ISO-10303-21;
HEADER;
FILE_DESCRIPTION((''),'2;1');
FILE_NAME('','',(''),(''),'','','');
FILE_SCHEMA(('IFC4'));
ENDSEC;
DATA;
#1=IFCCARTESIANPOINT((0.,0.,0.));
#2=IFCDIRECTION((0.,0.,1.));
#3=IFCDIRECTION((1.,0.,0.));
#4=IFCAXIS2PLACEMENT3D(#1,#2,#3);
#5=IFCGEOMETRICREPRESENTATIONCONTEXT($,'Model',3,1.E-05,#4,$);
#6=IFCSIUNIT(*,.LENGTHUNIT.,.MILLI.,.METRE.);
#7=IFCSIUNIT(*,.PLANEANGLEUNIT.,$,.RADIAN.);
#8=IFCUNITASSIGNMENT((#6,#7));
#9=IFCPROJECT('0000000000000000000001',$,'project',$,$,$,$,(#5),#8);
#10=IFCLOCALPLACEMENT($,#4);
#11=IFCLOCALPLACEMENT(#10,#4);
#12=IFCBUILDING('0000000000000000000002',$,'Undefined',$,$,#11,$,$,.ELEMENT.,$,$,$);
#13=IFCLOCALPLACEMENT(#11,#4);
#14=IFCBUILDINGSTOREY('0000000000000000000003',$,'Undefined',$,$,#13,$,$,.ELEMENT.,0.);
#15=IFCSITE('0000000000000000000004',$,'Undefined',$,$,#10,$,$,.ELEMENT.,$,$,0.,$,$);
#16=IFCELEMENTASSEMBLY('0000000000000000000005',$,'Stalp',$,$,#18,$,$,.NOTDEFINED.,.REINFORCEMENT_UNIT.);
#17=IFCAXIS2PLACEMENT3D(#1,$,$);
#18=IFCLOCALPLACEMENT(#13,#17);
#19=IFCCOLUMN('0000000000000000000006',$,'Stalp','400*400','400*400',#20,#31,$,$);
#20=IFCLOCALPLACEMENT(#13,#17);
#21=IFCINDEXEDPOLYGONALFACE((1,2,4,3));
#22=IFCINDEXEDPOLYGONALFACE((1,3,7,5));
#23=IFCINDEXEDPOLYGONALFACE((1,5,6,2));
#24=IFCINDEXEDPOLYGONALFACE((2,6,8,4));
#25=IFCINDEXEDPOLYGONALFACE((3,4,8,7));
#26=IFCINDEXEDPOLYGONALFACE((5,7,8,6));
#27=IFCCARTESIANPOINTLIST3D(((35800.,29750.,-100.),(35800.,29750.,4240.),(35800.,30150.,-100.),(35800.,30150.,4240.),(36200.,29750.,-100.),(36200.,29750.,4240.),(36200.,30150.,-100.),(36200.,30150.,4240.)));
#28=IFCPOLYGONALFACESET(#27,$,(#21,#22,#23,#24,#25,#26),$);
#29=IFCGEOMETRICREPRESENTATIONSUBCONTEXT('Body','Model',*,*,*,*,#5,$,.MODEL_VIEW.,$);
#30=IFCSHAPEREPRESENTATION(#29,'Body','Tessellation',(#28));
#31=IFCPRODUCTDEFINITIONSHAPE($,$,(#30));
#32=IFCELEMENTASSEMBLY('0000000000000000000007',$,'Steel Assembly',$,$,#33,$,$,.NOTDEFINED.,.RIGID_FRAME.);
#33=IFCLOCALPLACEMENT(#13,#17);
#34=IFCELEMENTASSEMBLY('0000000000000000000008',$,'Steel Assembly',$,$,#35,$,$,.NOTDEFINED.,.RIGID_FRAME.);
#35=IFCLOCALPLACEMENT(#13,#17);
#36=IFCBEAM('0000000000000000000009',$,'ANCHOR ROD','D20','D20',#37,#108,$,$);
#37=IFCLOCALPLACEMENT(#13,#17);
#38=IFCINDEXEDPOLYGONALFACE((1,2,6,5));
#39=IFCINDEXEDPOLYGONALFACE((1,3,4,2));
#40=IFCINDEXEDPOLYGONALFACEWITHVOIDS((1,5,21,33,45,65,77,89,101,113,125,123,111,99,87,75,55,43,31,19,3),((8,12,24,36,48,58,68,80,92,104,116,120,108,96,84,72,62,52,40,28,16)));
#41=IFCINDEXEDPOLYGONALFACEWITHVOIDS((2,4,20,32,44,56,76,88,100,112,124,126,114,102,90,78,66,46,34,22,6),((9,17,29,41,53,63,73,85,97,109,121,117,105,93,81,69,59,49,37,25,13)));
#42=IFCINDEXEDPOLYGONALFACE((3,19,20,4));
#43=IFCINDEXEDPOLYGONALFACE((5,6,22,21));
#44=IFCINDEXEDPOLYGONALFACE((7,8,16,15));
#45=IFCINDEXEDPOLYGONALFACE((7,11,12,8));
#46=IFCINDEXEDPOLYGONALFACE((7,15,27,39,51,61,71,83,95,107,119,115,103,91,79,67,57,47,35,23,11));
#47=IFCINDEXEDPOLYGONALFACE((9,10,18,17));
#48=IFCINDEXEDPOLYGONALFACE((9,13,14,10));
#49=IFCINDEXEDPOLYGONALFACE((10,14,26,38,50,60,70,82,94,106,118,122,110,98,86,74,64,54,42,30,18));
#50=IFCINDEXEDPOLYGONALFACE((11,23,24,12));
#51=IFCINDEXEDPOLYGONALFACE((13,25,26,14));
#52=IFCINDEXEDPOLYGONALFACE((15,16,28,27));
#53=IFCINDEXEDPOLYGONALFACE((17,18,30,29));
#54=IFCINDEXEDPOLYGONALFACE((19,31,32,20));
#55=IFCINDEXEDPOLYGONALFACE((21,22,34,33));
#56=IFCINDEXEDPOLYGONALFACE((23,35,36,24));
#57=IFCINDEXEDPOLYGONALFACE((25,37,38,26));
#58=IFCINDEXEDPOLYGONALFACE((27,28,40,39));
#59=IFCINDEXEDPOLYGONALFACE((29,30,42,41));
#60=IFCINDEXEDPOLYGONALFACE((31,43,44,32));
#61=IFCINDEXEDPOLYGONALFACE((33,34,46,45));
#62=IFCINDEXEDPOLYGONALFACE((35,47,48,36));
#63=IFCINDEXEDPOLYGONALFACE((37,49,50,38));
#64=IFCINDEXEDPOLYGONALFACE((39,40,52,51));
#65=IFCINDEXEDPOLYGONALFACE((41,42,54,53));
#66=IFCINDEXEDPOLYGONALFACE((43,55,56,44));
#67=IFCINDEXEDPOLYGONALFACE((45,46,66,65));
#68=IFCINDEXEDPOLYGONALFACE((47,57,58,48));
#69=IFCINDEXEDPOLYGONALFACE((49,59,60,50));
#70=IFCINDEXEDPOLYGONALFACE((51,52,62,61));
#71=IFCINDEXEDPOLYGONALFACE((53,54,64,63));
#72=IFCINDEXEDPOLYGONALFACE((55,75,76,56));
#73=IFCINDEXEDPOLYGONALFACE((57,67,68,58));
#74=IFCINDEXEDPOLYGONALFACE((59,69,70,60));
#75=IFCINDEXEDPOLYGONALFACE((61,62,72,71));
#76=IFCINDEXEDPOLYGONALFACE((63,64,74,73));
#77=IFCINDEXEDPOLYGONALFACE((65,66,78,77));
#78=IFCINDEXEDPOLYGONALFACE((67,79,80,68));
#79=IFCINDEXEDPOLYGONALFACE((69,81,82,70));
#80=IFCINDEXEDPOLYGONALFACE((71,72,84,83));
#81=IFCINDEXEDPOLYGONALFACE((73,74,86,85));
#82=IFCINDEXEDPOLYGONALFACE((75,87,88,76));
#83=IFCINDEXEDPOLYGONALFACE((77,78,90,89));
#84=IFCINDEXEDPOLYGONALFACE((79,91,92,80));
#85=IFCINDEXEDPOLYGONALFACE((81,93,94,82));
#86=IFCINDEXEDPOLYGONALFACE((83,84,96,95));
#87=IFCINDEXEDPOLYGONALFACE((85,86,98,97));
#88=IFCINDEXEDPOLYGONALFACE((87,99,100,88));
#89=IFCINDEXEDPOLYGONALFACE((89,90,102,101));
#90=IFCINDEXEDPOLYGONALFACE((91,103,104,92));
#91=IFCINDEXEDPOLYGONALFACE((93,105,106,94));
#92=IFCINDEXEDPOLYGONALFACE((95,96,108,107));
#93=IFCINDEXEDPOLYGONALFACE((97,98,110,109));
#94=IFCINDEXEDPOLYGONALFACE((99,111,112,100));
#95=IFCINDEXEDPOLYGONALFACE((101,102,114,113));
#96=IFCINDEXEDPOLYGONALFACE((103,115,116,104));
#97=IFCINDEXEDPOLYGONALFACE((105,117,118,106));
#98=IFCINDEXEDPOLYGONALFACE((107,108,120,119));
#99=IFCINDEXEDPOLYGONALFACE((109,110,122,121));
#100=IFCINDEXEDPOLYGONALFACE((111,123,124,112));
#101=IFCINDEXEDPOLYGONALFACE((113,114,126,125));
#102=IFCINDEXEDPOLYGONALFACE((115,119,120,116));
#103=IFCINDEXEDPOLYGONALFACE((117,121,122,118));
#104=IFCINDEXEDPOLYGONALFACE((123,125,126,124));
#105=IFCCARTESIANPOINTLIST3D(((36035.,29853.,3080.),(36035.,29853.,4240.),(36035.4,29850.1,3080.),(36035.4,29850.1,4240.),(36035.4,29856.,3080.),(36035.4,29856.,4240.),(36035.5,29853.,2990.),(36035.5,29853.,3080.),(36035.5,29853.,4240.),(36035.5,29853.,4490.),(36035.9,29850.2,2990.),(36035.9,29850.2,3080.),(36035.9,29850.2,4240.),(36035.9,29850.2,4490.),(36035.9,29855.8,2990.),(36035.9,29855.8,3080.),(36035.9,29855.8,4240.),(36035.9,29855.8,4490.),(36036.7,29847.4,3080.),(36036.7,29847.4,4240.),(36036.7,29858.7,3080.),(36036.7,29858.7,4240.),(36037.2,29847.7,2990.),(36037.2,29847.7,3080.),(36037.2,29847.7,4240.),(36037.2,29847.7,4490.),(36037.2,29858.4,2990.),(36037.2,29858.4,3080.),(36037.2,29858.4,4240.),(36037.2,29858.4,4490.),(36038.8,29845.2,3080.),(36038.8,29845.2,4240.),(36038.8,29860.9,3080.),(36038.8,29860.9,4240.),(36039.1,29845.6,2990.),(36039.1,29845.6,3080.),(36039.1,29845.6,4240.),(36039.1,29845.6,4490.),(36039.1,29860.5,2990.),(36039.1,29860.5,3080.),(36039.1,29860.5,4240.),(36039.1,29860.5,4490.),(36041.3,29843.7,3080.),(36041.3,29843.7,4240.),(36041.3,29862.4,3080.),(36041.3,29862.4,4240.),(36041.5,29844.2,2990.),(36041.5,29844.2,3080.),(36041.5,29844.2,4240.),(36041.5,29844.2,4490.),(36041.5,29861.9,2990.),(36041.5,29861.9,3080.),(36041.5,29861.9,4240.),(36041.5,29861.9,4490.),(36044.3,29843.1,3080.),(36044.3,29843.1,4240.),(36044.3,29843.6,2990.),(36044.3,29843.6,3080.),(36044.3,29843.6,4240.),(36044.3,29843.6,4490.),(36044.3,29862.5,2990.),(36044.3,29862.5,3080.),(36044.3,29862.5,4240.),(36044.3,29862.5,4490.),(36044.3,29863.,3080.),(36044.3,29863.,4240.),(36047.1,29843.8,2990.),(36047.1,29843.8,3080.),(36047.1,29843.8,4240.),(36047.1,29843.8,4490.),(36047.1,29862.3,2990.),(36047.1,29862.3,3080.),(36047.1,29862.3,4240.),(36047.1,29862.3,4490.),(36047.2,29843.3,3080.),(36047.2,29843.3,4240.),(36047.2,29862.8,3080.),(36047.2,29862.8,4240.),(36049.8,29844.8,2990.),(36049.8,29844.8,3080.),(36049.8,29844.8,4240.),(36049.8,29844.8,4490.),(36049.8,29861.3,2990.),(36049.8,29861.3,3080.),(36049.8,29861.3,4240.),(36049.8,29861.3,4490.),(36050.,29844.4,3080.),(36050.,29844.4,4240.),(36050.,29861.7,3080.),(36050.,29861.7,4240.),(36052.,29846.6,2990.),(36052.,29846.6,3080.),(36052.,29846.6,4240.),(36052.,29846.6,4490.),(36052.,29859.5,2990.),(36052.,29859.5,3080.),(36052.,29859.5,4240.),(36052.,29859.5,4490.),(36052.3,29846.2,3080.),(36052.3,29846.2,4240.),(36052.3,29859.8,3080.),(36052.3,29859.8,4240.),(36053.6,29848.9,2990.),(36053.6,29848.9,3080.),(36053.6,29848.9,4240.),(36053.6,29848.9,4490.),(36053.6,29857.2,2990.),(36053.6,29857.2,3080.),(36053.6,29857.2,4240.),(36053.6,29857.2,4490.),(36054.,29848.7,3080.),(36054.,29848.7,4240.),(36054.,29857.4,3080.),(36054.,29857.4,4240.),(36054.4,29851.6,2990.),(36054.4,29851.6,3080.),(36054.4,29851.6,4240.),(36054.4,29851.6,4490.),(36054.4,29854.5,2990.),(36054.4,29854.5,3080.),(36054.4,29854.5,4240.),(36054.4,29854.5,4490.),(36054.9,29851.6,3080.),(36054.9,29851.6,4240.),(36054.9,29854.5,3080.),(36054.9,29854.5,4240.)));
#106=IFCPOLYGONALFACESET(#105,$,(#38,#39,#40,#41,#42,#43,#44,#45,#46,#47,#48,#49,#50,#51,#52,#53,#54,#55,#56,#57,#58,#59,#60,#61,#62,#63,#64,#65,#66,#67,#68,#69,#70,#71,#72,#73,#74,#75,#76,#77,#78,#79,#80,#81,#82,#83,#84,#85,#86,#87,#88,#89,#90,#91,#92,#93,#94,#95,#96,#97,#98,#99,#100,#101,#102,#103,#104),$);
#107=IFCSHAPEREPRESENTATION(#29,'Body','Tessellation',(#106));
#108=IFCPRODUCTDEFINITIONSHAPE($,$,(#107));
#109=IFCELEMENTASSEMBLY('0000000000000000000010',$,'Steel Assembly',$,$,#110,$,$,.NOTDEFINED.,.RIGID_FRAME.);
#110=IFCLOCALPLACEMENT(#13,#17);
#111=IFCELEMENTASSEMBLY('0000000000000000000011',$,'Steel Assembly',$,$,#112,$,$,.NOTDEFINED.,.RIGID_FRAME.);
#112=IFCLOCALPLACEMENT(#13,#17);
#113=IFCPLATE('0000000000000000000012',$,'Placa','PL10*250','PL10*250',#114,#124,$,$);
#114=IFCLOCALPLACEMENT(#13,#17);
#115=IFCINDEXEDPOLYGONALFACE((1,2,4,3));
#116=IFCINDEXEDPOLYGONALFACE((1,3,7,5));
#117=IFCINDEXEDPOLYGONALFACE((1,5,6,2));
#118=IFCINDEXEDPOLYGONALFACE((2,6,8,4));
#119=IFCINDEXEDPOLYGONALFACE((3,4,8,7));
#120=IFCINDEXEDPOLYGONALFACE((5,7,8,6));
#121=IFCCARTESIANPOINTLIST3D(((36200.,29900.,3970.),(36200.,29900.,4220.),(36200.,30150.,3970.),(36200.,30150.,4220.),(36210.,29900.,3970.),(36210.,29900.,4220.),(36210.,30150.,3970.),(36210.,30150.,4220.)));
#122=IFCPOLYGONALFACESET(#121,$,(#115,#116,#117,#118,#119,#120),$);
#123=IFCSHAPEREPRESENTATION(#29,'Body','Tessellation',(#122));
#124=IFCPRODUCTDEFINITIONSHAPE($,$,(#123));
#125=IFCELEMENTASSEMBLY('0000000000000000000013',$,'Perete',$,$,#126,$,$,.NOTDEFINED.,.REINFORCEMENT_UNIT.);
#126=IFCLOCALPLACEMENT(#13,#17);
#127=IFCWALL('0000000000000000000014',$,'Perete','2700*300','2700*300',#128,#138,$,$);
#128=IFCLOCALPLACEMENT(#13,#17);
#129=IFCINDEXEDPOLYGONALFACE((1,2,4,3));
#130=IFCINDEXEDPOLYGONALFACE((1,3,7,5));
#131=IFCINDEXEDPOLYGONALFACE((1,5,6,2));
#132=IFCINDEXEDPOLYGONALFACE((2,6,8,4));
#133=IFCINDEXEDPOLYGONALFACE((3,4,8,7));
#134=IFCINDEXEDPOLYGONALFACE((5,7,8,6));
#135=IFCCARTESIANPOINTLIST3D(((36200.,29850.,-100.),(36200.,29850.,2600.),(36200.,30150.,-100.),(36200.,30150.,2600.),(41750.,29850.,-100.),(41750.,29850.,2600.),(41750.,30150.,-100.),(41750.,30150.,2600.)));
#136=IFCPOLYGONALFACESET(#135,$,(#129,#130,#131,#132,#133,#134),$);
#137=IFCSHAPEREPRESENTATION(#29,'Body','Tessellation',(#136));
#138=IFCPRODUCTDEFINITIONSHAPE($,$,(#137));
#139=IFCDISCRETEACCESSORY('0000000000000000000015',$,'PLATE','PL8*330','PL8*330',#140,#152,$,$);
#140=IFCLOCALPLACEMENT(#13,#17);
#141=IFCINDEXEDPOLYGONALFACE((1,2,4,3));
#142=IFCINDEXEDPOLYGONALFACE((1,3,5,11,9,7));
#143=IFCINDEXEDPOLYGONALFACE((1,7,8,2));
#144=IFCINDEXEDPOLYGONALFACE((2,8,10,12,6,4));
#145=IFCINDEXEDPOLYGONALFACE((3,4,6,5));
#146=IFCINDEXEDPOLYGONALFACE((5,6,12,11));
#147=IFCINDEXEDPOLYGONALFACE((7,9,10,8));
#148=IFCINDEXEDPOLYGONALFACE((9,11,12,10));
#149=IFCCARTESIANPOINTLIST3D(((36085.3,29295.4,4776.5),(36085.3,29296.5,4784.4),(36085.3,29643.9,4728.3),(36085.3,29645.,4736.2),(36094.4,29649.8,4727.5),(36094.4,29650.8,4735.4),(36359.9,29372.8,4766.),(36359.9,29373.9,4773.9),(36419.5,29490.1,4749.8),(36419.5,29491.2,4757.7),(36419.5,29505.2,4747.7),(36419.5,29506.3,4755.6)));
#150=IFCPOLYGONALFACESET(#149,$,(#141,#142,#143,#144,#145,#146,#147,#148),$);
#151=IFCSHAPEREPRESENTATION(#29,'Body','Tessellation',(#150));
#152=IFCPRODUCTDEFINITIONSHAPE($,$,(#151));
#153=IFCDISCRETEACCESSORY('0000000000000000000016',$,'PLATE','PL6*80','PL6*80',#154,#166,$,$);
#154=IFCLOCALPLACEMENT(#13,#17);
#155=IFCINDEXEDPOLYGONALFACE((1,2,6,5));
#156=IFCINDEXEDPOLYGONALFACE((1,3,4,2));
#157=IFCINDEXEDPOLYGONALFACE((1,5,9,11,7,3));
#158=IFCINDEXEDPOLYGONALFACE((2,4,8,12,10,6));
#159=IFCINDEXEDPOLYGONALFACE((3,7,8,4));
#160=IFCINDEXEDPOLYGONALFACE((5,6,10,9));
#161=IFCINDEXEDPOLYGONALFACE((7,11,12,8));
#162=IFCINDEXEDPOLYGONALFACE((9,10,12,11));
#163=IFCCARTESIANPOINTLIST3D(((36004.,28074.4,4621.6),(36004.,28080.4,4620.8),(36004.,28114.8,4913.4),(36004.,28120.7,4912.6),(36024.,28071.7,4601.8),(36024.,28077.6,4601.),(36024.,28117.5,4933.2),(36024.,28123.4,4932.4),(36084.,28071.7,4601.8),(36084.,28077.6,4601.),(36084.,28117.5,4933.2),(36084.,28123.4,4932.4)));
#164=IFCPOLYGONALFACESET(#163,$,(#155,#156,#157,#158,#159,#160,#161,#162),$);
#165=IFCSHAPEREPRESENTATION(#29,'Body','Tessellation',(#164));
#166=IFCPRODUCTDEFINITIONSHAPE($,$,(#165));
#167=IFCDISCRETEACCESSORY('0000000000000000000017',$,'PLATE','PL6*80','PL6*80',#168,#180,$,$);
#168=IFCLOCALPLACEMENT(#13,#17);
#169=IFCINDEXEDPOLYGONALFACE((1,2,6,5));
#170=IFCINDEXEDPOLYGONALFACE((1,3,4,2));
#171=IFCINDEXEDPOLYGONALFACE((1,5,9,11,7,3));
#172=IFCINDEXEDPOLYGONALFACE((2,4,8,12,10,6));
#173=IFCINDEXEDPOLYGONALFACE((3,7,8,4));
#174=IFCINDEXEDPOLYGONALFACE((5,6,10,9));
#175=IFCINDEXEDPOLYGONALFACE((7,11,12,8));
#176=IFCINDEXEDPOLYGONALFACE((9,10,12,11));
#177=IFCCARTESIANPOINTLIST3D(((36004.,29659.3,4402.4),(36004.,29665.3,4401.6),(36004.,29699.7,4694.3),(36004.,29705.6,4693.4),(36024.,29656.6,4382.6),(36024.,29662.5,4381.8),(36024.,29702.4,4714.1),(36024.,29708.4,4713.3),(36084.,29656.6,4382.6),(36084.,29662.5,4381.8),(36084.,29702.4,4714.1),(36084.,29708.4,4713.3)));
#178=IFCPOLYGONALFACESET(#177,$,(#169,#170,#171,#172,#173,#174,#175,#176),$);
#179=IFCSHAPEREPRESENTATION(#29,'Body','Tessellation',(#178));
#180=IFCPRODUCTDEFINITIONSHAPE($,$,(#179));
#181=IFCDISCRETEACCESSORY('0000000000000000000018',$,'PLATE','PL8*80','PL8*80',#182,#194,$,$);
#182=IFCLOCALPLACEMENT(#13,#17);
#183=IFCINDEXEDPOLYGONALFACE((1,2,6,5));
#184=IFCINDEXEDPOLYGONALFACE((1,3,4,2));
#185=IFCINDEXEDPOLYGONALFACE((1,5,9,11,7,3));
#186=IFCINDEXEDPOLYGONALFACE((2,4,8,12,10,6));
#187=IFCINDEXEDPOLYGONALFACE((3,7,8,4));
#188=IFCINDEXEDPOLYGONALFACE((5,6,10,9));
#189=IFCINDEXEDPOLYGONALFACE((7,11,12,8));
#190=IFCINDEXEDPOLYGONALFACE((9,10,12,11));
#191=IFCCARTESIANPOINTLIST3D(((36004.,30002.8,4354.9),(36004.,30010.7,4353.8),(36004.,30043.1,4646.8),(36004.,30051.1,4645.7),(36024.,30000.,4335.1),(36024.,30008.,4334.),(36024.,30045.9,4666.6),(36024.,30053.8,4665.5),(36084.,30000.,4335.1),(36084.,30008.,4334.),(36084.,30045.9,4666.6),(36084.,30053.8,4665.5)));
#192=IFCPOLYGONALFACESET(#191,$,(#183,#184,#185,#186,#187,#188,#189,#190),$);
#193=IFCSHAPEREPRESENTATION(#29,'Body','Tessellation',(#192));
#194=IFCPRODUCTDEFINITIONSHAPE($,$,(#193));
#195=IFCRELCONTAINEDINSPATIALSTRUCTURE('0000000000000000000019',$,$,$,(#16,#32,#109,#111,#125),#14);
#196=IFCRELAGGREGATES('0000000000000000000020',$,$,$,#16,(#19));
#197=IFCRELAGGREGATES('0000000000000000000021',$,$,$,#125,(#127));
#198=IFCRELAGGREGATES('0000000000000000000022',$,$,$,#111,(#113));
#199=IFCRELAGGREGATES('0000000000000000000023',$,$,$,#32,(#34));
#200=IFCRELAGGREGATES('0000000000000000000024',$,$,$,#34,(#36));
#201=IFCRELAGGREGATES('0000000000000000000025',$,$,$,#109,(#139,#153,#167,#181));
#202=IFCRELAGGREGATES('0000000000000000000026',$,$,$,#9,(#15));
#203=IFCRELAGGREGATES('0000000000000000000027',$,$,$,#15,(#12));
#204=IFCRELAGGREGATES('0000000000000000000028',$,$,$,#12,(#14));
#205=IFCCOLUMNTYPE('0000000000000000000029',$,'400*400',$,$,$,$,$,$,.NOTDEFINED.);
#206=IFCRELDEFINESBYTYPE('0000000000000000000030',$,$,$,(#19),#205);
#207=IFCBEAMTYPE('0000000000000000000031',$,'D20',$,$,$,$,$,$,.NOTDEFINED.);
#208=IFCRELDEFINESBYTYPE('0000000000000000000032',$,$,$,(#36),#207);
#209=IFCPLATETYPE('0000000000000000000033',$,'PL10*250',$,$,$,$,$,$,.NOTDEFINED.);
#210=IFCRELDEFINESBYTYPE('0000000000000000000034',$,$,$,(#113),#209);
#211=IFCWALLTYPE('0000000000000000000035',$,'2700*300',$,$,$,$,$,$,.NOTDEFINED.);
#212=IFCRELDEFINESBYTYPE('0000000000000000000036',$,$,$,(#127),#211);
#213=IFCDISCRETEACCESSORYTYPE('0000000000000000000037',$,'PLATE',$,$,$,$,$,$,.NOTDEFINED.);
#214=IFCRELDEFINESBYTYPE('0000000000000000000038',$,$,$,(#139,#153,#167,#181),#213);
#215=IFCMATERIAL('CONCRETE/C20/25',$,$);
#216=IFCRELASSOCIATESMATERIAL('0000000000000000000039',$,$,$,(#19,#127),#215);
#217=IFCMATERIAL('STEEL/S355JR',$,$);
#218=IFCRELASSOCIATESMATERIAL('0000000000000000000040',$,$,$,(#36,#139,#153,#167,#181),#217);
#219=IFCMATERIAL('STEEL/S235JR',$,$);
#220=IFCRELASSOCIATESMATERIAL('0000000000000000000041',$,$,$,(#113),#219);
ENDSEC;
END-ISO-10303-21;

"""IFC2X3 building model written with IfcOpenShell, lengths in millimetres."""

from ifc_helpers import new_model, si_unit, frame, frame_2d, origin_with_axes, origin_2d_with_axis, place, context, subcontext, project, spatial, polyline, rectangle, circle, outline, extrude, boolean, material, type_object, element, aggregate, save


model = new_model("IFC2X3")

# Units and contexts
model_context = context("Model", 3, precision=1e-05, world=origin_with_axes())
body_context = subcontext(model_context, "Body", "Model", "MODEL_VIEW")
ifc_project = project(units=[si_unit("LENGTHUNIT", "METRE", prefix="MILLI"), si_unit("PLANEANGLEUNIT", "RADIAN")], contexts=[model_context])

# Site, building, storey
site_placement = place(None, origin_with_axes())
site = spatial("IfcSite", under=ifc_project, at=site_placement, Name="Undefined", CompositionType="ELEMENT", RefElevation=0.0)
building_placement = place(site_placement, origin_with_axes())
building = spatial("IfcBuilding", under=site, at=building_placement, Name="Undefined", CompositionType="ELEMENT")
storey_placement = place(building_placement, origin_with_axes())
storey = spatial("IfcBuildingStorey", under=building, at=storey_placement, Name="Undefined", CompositionType="ELEMENT", Elevation=0.0)

# Element assembly, column
assembly_1_placement = place(storey_placement, origin_with_axes())
assembly_1 = element("IfcElementAssembly", 1, at=assembly_1_placement, inside=storey, Name="Stalp", AssemblyPlace="NOTDEFINED", PredefinedType="REINFORCEMENT_UNIT")
ifc_material_1 = material(Name="CONCRETE/C20/25")
column_type = type_object("IfcColumnType", Name="400*400", PredefinedType="NOTDEFINED")
column_placement = place(assembly_1_placement, frame((36000.0, 29950.0, -100.0), z_axis=(0.0, 0.0, 1.0), x_axis=(0.0, 1.0, 0.0)))
column = element("IfcColumn", 2, at=column_placement, type_object=column_type, material=ifc_material_1, Name="Stalp", Description="400*400", ObjectType="400*400", context=body_context, shape_type="SweptSolid", body=[
    extrude(rectangle(XDim=400.0, YDim=400.0, at=origin_2d_with_axis()), frame((0.0, 0.0, 4340.0), z_axis=(0.0, 0.0, -1.0), x_axis=(0.0, 1.0, 0.0)), (0.0, 0.0, 1.0), 4340.0),
])
aggregate(assembly_1, [column])

# Shared definitions
ifc_material_2 = material(Name="STEEL/S355JR")

# Element assemblies, beam
assembly_2_placement = place(storey_placement, origin_with_axes())
assembly_2 = element("IfcElementAssembly", 3, at=assembly_2_placement, inside=storey, Name="Steel Assembly", AssemblyPlace="NOTDEFINED", PredefinedType="RIGID_FRAME")
assembly_3_placement = place(assembly_2_placement, origin_with_axes())
assembly_3 = element("IfcElementAssembly", 4, at=assembly_3_placement, Name="Steel Assembly", AssemblyPlace="NOTDEFINED", PredefinedType="RIGID_FRAME")
beam_type_1 = type_object("IfcBeamType", Name="D20", PredefinedType="NOTDEFINED")
beam_1_placement = place(assembly_3_placement, frame((36045.0, 29853.0, 4240.0), z_axis=(0.0, -1.0, 0.0), x_axis=(0.0, 0.0, -1.0)))
beam_1 = element("IfcBeam", 5, at=beam_1_placement, type_object=beam_type_1, material=ifc_material_2, Name="ANCHOR ROD", Description="D20", ObjectType="D20", context=body_context, shape_type="CSG", body=[
    boolean("UNION", boolean("UNION", extrude(circle(Radius=10.0, at=origin_2d_with_axis()), frame((1160.0, 0.0, 0.0), z_axis=(-1.0, 0.0, 0.0), x_axis=(0.0, -1.0, 0.0)), (0.0, 0.0, 1.0), 1160.0), extrude(circle(Radius=9.5, at=origin_2d_with_axis()), frame((1250.0, 0.0, 0.0), z_axis=(-1.0, 0.0, 0.0), x_axis=(0.0, -1.0, 0.0)), (0.0, 0.0, 1.0), 90.0)), extrude(circle(Radius=9.5, at=origin_2d_with_axis()), frame((0.0, 0.0, 0.0), z_axis=(-1.0, 0.0, 0.0), x_axis=(0.0, -1.0, 0.0)), (0.0, 0.0, 1.0), 250.0)),
])

# Element assembly
assembly_4_placement = place(storey_placement, origin_with_axes())
assembly_4 = element("IfcElementAssembly", 6, at=assembly_4_placement, inside=storey, Name="Steel Assembly", AssemblyPlace="NOTDEFINED", PredefinedType="RIGID_FRAME")

# Element assembly, plate
assembly_5_placement = place(storey_placement, origin_with_axes())
assembly_5 = element("IfcElementAssembly", 7, at=assembly_5_placement, inside=storey, Name="Steel Assembly", AssemblyPlace="NOTDEFINED", PredefinedType="RIGID_FRAME")
ifc_material_3 = material(Name="STEEL/S235JR")
plate_type = type_object("IfcPlateType", Name="PL10*250", PredefinedType="NOTDEFINED")
plate_placement = place(assembly_5_placement, frame((36205.0, 29900.0, 4220.0), z_axis=(1.0, 0.0, 0.0), x_axis=(0.0, 0.0, -1.0)))
plate = element("IfcPlate", 8, at=plate_placement, type_object=plate_type, material=ifc_material_3, Name="Placa", Description="PL10*250", ObjectType="PL10*250", context=body_context, shape_type="SweptSolid", body=[
    extrude(outline(polyline([(0.0, 0.0), (250.0, 0.0), (250.0, 250.0), (0.0, 250.0), (0.0, 0.0)])), frame((0.0, 0.0, -5.0), z_axis=(0.0, 0.0, 1.0), x_axis=(1.0, 0.0, 0.0)), (0.0, 0.0, 1.0), 10.0),
])

# Element assembly, wall
assembly_6_placement = place(storey_placement, origin_with_axes())
assembly_6 = element("IfcElementAssembly", 9, at=assembly_6_placement, inside=storey, Name="Perete", AssemblyPlace="NOTDEFINED", PredefinedType="REINFORCEMENT_UNIT")
wall_type = type_object("IfcWallType", Name="2700*300", PredefinedType="NOTDEFINED")
wall_placement = place(assembly_6_placement, frame((36200.0, 30000.0, -100.0), z_axis=(0.0, 0.0, 1.0), x_axis=(1.0, 0.0, 0.0)))
wall = element("IfcWall", 10, at=wall_placement, type_object=wall_type, material=ifc_material_1, Name="Perete", Description="2700*300", ObjectType="2700*300", context=body_context, shape_type="SweptSolid", body=[
    extrude(rectangle(XDim=5550.0, YDim=300.0, at=frame_2d((0.0, 2775.0), x_axis=(0.0, -1.0))), frame((0.0, 0.0, 0.0), z_axis=(0.0, 0.0, 1.0), x_axis=(0.0, -1.0, 0.0)), (0.0, 0.0, 1.0), 2700.0),
])
aggregate(assembly_6, [wall])

# Discrete accessories
discrete_accessory_type_1 = type_object("IfcDiscreteAccessoryType", Name="PLATE")
discrete_accessory_1_placement = place(assembly_4_placement, frame((36085.3, 29295.9, 4780.5), z_axis=(0.000554, -0.13698, -0.990574), x_axis=(0.0, 0.990574, -0.13698)))
discrete_accessory_1 = element("IfcDiscreteAccessory", 11, at=discrete_accessory_1_placement, type_object=discrete_accessory_type_1, material=ifc_material_2, Name="PLATE", Description="PL8*330", ObjectType="PL8*330", context=body_context, shape_type="SweptSolid", body=[
    extrude(outline(polyline([(0.0, 0.0), (351.8, 0.0), (357.7, 9.1), (211.8, 334.2), (196.6, 334.2), (78.2, 274.6), (0.0, 0.0)])), frame((0.0, 0.0, -4.0), z_axis=(0.0, 0.0, 1.0), x_axis=(1.0, 0.0, 0.0)), (0.0, 0.0, 1.0), 8.0),
])
discrete_accessory_2_placement = place(assembly_4_placement, frame((36084.0, 28074.6, 4601.4), z_axis=(0.0, 0.990574, -0.13698), x_axis=(-1.0, 0.0, 0.0)))
discrete_accessory_2 = element("IfcDiscreteAccessory", 12, at=discrete_accessory_2_placement, type_object=discrete_accessory_type_1, material=ifc_material_2, Name="PLATE", Description="PL6*80", ObjectType="PL6*80", context=body_context, shape_type="SweptSolid", body=[
    extrude(outline(polyline([(0.0, 0.0), (60.0, 0.0), (80.0, 20.0), (80.0, 314.6), (60.0, 334.6), (0.0, 334.6), (0.0, 0.0)])), frame((0.0, 0.0, -3.0), z_axis=(0.0, 0.0, 1.0), x_axis=(1.0, 0.0, 0.0)), (0.0, 0.0, 1.0), 6.0),
])
discrete_accessory_3_placement = place(assembly_4_placement, frame((36084.0, 29659.6, 4382.2), z_axis=(0.0, 0.990574, -0.13698), x_axis=(-1.0, 0.0, 0.0)))
discrete_accessory_3 = element("IfcDiscreteAccessory", 13, at=discrete_accessory_3_placement, type_object=discrete_accessory_type_1, material=ifc_material_2, Name="PLATE", Description="PL6*80", ObjectType="PL6*80", context=body_context, shape_type="SweptSolid", body=[
    extrude(outline(polyline([(0.0, 0.0), (60.0, 0.0), (80.0, 20.0), (80.0, 314.6), (60.0, 334.6), (0.0, 334.6), (0.0, 0.0)])), frame((0.0, 0.0, -3.0), z_axis=(0.0, 0.0, 1.0), x_axis=(1.0, 0.0, 0.0)), (0.0, 0.0, 1.0), 6.0),
])
discrete_accessory_4_placement = place(assembly_4_placement, frame((36084.0, 30004.0, 4334.6), z_axis=(0.0, 0.990574, -0.13698), x_axis=(-1.0, 0.0, 0.0)))
discrete_accessory_4 = element("IfcDiscreteAccessory", 14, at=discrete_accessory_4_placement, type_object=discrete_accessory_type_1, material=ifc_material_2, Name="PLATE", Description="PL8*80", ObjectType="PL8*80", context=body_context, shape_type="SweptSolid", body=[
    extrude(outline(polyline([(0.0, 0.0), (60.0, 0.0), (80.0, 20.0), (80.0, 314.6), (60.0, 334.6), (0.0, 334.6), (0.0, 0.0)])), frame((0.0, 0.0, -4.0), z_axis=(0.0, 0.0, 1.0), x_axis=(1.0, 0.0, 0.0)), (0.0, 0.0, 1.0), 8.0),
])

aggregate(assembly_5, [plate])

aggregate(assembly_2, [assembly_3])

aggregate(assembly_3, [beam_1])

aggregate(assembly_4, [discrete_accessory_1, discrete_accessory_2, discrete_accessory_3, discrete_accessory_4])

save(model, "model.ifc")
